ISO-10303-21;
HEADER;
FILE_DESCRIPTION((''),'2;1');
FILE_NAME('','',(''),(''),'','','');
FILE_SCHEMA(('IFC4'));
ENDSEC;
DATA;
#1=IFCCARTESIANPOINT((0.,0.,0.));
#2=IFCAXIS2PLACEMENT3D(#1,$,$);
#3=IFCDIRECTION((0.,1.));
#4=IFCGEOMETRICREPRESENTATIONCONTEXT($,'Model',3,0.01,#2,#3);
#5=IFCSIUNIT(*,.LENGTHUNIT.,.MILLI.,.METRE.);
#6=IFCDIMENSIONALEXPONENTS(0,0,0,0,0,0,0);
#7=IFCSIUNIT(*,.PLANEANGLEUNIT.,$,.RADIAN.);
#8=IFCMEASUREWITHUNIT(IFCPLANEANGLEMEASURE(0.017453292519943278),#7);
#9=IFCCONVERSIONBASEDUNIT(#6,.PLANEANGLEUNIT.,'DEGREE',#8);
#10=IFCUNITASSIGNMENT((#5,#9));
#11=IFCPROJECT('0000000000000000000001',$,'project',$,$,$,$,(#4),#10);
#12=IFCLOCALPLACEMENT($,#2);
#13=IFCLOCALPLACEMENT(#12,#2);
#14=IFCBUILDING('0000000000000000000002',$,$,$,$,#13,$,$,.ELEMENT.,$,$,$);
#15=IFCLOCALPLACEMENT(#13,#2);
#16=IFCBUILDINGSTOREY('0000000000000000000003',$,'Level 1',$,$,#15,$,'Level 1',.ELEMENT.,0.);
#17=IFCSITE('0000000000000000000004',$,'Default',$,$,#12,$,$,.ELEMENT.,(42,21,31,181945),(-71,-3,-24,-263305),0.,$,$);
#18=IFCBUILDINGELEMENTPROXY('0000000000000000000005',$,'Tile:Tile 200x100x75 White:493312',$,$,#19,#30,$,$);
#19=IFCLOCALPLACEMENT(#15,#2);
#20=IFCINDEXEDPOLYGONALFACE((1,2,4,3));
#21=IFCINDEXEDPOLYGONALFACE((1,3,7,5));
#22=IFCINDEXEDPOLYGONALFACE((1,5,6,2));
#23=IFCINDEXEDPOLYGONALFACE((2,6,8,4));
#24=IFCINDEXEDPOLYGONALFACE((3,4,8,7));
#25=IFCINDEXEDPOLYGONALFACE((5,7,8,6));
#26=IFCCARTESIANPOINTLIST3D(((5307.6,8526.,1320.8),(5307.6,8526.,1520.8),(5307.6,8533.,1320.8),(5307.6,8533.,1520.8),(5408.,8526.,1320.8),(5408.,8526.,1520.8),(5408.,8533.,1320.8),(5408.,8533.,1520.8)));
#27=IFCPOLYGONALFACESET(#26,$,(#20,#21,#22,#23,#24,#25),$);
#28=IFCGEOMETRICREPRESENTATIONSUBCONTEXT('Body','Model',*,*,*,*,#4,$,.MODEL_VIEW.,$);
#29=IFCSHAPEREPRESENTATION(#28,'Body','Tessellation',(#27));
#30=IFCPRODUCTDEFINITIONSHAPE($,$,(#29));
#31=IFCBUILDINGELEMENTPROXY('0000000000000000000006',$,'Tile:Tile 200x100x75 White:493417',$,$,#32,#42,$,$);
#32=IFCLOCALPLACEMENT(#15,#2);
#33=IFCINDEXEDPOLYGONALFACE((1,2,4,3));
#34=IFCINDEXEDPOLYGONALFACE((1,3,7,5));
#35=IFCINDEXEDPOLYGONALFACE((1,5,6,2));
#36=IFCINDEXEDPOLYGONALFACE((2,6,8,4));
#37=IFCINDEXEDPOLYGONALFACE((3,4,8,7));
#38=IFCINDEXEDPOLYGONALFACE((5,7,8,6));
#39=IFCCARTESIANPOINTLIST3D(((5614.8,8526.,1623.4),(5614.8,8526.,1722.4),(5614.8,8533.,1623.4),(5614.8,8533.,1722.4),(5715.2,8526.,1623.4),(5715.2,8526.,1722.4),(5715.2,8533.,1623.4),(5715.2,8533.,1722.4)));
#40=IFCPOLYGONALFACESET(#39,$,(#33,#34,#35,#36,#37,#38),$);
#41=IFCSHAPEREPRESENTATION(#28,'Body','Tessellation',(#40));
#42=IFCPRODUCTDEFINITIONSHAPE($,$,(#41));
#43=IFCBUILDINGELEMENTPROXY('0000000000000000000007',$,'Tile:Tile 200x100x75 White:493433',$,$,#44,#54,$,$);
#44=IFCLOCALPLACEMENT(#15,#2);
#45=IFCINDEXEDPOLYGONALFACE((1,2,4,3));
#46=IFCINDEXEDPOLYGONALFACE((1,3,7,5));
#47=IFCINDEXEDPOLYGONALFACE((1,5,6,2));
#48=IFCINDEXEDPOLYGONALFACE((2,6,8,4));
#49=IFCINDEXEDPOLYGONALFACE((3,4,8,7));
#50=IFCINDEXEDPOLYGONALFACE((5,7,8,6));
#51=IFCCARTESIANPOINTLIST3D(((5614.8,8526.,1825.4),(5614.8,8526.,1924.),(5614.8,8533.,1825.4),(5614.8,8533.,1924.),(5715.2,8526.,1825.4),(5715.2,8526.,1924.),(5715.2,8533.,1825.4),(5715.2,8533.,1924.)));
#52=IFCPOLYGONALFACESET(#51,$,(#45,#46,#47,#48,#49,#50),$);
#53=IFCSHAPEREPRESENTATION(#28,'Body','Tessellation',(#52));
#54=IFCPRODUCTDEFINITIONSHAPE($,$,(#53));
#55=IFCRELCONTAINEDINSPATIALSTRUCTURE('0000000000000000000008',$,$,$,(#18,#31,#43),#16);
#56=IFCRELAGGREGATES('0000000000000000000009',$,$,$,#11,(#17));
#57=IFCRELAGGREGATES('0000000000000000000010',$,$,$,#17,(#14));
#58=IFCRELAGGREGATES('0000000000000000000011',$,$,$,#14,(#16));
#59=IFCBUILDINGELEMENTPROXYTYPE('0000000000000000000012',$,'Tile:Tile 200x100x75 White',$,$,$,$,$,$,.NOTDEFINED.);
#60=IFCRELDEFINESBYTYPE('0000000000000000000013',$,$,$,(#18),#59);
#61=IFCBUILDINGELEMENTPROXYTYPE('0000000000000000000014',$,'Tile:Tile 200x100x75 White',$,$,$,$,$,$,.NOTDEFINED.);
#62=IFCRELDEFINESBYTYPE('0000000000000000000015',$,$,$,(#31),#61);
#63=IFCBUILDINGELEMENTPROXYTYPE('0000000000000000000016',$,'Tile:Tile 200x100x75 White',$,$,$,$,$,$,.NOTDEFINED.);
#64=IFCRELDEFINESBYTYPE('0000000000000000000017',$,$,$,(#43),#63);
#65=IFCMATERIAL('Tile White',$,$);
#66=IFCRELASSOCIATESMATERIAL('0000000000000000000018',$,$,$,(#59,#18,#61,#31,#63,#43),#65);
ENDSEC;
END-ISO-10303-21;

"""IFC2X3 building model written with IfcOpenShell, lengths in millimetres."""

from ifc_helpers import new_model, entity, si_unit, converted_unit, direction, frame, frame_2d, origin, origin_2d_with_axis, place, context, subcontext, project, spatial, rectangle, extrude, source, transform, mapped, material, type_object, type_shapes, element, save


model = new_model("IFC2X3")

# Units and contexts
model_context = context("Model", 3, precision=0.01, world=origin(), true_north=direction((0.0, 1.0)))
body_context = subcontext(model_context, "Body", "Model", "MODEL_VIEW")
ifc_project = project(units=[si_unit("LENGTHUNIT", "METRE", prefix="MILLI"), converted_unit("PLANEANGLEUNIT", "DEGREE", entity("IfcPlaneAngleMeasure", 0.017453292519943278), si_unit("PLANEANGLEUNIT", "RADIAN"), dimensions=[0, 0, 0, 0, 0, 0, 0])], contexts=[model_context])

# Site, building, storey
site_placement = place(None, origin())
site = spatial("IfcSite", under=ifc_project, at=site_placement, Name="Default", CompositionType="ELEMENT", RefLatitude=(42, 21, 31, 181945), RefLongitude=(-71, -3, -24, -263305), RefElevation=0.0)
building_placement = place(site_placement, origin())
building = spatial("IfcBuilding", under=site, at=building_placement, CompositionType="ELEMENT")
storey_placement = place(building_placement, origin())
storey = spatial("IfcBuildingStorey", under=building, at=storey_placement, Name="Level 1", LongName="Level 1", CompositionType="ELEMENT", Elevation=0.0)

# Building element proxies
ifc_material_1 = material(Name="Tile White")
building_element_proxy_type_1 = type_object("IfcBuildingElementProxyType", Name="Tile:Tile 200x100x75 White", PredefinedType="NOTDEFINED", material=ifc_material_1)
shared_shape_1 = source(origin(), body_context, "Body", "SweptSolid", [
    extrude(rectangle(XDim=200.0, YDim=100.4, at=frame_2d((0.0, 0.0), x_axis=(1.0, 0.0))), frame((-50.2, -100.0, 0.0), z_axis=(0.0, 0.0, 1.0), x_axis=(0.0, -1.0, 0.0)), (0.0, 0.0, 1.0), 7.0),
])
type_shapes(building_element_proxy_type_1, [shared_shape_1])
for number, where, z_axis, x_axis, name in (
    (1, (5408.0, 8533.0, 1520.8), (0.0, -1.0, 0.0), (1.0, 0.0, 0.0), "Tile:Tile 200x100x75 White:493312"),
):
    element("IfcBuildingElementProxy", number, at=place(storey_placement, frame(where, z_axis=z_axis, x_axis=x_axis)), inside=storey, type_object=building_element_proxy_type_1, material=ifc_material_1, Name=name, context=body_context, shape_type="MappedRepresentation", body=[
        mapped(shared_shape_1, transform((0.0, 0.0, 0.0), scale=1.0)),
    ])
building_element_proxy_type_2 = type_object("IfcBuildingElementProxyType", Name="Tile:Tile 200x100x75 White", PredefinedType="NOTDEFINED", material=ifc_material_1)
shared_shape_2 = source(origin(), body_context, "Body", "SweptSolid", [
    extrude(rectangle(XDim=99.0, YDim=100.4, at=origin_2d_with_axis()), frame((-50.2, -49.5, 0.0), z_axis=(0.0, 0.0, 1.0), x_axis=(0.0, -1.0, 0.0)), (0.0, 0.0, 1.0), 7.0),
])
type_shapes(building_element_proxy_type_2, [shared_shape_2])
proxy_1_placement = place(storey_placement, frame((5715.2, 8533.0, 1722.4), z_axis=(0.0, -1.0, 0.0), x_axis=(1.0, 0.0, 0.0)))
element("IfcBuildingElementProxy", 2, at=proxy_1_placement, inside=storey, type_object=building_element_proxy_type_2, material=ifc_material_1, Name="Tile:Tile 200x100x75 White:493417", context=body_context, shape_type="MappedRepresentation", body=[
    mapped(shared_shape_2, transform((0.0, 0.0, 0.0), scale=1.0)),
])
building_element_proxy_type_3 = type_object("IfcBuildingElementProxyType", Name="Tile:Tile 200x100x75 White", PredefinedType="NOTDEFINED", material=ifc_material_1)
shared_shape_3 = source(origin(), body_context, "Body", "SweptSolid", [
    extrude(rectangle(XDim=98.6, YDim=100.4, at=origin_2d_with_axis()), frame((-50.2, -49.3, 0.0), z_axis=(0.0, 0.0, 1.0), x_axis=(0.0, -1.0, 0.0)), (0.0, 0.0, 1.0), 7.0),
])
type_shapes(building_element_proxy_type_3, [shared_shape_3])
proxy_2_placement = place(storey_placement, frame((5715.2, 8533.0, 1924.0), z_axis=(0.0, -1.0, 0.0), x_axis=(1.0, 0.0, 0.0)))
element("IfcBuildingElementProxy", 3, at=proxy_2_placement, inside=storey, type_object=building_element_proxy_type_3, material=ifc_material_1, Name="Tile:Tile 200x100x75 White:493433", context=body_context, shape_type="MappedRepresentation", body=[
    mapped(shared_shape_3, transform((0.0, 0.0, 0.0), scale=1.0)),
])

save(model, "model.ifc")
